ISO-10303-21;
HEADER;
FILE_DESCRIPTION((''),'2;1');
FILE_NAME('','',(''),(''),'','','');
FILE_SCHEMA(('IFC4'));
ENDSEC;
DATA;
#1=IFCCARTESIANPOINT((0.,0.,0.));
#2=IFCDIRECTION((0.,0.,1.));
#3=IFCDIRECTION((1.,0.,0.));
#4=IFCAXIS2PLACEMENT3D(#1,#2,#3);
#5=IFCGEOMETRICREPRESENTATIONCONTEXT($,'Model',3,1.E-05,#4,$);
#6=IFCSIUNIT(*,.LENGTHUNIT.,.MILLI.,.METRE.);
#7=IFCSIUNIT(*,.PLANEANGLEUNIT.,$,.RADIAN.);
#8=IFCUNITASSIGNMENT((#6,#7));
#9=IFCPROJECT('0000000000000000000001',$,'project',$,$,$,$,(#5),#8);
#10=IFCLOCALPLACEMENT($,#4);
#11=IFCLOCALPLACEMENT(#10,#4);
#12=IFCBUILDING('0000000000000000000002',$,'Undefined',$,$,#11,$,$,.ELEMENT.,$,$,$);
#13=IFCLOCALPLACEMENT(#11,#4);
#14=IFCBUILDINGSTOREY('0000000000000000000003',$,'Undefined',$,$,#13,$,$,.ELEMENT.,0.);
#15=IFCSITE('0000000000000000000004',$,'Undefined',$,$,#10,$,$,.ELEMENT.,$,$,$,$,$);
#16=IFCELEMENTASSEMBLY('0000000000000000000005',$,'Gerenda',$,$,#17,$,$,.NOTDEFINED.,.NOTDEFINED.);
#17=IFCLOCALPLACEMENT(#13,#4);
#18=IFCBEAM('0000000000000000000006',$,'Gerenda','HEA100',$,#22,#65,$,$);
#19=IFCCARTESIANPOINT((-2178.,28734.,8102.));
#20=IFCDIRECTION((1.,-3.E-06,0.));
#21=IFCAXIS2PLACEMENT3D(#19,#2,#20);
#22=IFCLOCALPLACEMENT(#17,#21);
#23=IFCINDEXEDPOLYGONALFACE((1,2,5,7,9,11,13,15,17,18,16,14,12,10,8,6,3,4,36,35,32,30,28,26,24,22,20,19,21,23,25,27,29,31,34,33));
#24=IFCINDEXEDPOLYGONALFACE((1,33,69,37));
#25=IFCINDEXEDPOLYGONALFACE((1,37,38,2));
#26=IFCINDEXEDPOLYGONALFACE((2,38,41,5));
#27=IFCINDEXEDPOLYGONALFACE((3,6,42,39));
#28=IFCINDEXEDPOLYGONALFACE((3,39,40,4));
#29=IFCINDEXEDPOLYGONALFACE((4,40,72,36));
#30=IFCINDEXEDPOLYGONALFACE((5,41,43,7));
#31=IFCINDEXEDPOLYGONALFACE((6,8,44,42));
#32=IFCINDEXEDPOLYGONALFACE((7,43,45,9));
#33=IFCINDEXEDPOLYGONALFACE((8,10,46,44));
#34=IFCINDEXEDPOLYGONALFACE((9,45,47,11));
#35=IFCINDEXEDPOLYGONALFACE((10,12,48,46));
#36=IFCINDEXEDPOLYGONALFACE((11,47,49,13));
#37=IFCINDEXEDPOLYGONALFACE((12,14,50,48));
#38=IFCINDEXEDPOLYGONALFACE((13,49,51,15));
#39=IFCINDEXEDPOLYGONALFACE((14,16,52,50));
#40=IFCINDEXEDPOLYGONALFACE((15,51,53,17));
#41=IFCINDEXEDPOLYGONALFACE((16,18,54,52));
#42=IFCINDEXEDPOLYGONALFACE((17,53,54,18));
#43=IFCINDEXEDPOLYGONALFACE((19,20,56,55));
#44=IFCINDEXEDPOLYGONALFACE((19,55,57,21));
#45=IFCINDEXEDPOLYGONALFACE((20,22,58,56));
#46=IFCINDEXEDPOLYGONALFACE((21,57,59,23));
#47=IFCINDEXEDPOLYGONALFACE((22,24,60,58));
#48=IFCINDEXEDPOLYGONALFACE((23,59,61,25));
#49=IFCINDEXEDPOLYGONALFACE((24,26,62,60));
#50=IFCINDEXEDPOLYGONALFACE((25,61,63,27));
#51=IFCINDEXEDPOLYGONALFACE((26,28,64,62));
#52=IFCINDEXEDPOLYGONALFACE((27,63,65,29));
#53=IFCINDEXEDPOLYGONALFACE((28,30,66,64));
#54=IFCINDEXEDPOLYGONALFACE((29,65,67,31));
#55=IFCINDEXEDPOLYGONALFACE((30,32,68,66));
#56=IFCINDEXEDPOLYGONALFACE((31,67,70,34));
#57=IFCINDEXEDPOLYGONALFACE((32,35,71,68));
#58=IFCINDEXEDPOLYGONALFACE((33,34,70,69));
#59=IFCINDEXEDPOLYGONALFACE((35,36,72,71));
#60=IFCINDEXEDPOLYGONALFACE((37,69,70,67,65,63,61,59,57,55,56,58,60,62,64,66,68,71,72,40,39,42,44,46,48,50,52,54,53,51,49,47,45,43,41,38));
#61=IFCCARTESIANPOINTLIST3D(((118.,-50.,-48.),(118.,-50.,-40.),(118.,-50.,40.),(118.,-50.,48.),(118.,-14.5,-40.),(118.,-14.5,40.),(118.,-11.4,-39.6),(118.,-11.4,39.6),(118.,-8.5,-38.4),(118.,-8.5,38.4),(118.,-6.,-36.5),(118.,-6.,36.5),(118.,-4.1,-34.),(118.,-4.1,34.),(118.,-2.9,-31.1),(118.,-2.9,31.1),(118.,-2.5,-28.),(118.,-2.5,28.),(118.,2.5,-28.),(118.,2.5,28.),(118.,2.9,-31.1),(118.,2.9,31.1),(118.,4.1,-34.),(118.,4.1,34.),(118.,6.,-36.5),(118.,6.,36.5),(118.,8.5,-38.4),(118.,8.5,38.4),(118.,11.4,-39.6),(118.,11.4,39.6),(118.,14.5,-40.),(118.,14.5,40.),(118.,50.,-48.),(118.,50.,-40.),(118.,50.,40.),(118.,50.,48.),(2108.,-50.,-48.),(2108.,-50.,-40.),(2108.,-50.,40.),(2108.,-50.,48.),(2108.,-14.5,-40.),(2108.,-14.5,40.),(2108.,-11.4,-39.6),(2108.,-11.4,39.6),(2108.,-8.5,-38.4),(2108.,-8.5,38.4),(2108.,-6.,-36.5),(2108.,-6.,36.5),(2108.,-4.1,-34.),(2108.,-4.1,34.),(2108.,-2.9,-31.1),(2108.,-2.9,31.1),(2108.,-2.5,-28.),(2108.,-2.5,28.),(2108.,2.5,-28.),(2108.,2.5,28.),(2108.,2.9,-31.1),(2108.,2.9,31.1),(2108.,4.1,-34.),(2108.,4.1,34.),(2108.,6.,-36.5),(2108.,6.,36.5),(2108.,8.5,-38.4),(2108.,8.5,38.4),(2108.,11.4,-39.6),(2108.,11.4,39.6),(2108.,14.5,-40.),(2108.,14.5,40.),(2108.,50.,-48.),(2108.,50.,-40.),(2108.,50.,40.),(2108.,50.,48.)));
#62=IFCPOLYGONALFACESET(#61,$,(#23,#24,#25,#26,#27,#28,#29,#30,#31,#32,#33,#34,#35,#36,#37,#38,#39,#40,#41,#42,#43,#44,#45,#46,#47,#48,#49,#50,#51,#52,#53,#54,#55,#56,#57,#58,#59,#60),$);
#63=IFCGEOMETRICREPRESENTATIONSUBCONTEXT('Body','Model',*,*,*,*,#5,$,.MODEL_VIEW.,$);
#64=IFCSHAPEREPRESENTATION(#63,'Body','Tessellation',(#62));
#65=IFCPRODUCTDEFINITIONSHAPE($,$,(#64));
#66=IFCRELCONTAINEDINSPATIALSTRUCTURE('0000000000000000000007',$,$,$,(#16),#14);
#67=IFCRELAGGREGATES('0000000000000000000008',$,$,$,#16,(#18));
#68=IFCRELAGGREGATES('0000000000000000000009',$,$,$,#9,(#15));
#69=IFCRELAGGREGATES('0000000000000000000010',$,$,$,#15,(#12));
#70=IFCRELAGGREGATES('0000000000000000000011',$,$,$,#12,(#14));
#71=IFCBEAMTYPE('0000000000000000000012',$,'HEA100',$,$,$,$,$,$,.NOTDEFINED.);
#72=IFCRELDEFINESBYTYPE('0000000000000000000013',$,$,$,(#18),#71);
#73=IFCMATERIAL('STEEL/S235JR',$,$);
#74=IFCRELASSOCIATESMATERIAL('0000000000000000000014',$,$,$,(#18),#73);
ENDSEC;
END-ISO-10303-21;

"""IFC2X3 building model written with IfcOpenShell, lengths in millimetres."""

from ifc_helpers import new_model, si_unit, frame, origin_with_axes, origin_2d_with_axis, place, context, subcontext, project, spatial, i_section, extrude, clip, halfspace, material, type_object, element, aggregate, save


model = new_model("IFC2X3")

# Units and contexts
model_context = context("Model", 3, precision=1e-05, world=origin_with_axes())
body_context = subcontext(model_context, "Body", "Model", "MODEL_VIEW")
ifc_project = project(units=[si_unit("LENGTHUNIT", "METRE", prefix="MILLI"), si_unit("PLANEANGLEUNIT", "RADIAN")], contexts=[model_context])

# Site, building, storey
site_placement = place(None, origin_with_axes())
site = spatial("IfcSite", under=ifc_project, at=site_placement, Name="Undefined", CompositionType="ELEMENT")
building_placement = place(site_placement, origin_with_axes())
building = spatial("IfcBuilding", under=site, at=building_placement, Name="Undefined", CompositionType="ELEMENT")
storey_placement = place(building_placement, origin_with_axes())
storey = spatial("IfcBuildingStorey", under=building, at=storey_placement, Name="Undefined", CompositionType="ELEMENT", Elevation=0.0)

# Element assembly, beam
ifc_material_1 = material(Name="STEEL/S235JR")
assembly_1_placement = place(storey_placement, origin_with_axes())
assembly_1 = element("IfcElementAssembly", 1, at=assembly_1_placement, inside=storey, Name="Gerenda", AssemblyPlace="NOTDEFINED", PredefinedType="NOTDEFINED")
beam_type_1 = type_object("IfcBeamType", Name="HEA100", PredefinedType="NOTDEFINED")
beam_1_placement = place(assembly_1_placement, frame((-2178.0, 28734.0, 8102.0), z_axis=(0.0, 0.0, 1.0), x_axis=(1.0, -0.000003, 0.0)))
beam_1 = element("IfcBeam", 2, at=beam_1_placement, type_object=beam_type_1, material=ifc_material_1, Name="Gerenda", Description="HEA100", context=body_context, shape_type="Clipping", body=[
    clip(clip(extrude(i_section(OverallWidth=100.0, OverallDepth=96.0, WebThickness=5.0, FlangeThickness=8.0, FilletRadius=12.0, at=origin_2d_with_axis()), frame((2178.0, 0.0, 0.0), z_axis=(-1.0, 0.0, 0.0), x_axis=(0.0, -1.0, 0.0)), (0.0, 0.0, 1.0), 2178.0), halfspace(frame((2108.0, 0.0, -48.0), z_axis=(-1.0, 0.0, 0.0), x_axis=(0.0, 1.0, 0.0)), True)), halfspace(frame((118.0, 0.0, -48.0), z_axis=(1.0, -0.000002, 0.0), x_axis=(-0.000002, -1.0, 0.0)), True)),
])

aggregate(assembly_1, [beam_1])

save(model, "model.ifc")
